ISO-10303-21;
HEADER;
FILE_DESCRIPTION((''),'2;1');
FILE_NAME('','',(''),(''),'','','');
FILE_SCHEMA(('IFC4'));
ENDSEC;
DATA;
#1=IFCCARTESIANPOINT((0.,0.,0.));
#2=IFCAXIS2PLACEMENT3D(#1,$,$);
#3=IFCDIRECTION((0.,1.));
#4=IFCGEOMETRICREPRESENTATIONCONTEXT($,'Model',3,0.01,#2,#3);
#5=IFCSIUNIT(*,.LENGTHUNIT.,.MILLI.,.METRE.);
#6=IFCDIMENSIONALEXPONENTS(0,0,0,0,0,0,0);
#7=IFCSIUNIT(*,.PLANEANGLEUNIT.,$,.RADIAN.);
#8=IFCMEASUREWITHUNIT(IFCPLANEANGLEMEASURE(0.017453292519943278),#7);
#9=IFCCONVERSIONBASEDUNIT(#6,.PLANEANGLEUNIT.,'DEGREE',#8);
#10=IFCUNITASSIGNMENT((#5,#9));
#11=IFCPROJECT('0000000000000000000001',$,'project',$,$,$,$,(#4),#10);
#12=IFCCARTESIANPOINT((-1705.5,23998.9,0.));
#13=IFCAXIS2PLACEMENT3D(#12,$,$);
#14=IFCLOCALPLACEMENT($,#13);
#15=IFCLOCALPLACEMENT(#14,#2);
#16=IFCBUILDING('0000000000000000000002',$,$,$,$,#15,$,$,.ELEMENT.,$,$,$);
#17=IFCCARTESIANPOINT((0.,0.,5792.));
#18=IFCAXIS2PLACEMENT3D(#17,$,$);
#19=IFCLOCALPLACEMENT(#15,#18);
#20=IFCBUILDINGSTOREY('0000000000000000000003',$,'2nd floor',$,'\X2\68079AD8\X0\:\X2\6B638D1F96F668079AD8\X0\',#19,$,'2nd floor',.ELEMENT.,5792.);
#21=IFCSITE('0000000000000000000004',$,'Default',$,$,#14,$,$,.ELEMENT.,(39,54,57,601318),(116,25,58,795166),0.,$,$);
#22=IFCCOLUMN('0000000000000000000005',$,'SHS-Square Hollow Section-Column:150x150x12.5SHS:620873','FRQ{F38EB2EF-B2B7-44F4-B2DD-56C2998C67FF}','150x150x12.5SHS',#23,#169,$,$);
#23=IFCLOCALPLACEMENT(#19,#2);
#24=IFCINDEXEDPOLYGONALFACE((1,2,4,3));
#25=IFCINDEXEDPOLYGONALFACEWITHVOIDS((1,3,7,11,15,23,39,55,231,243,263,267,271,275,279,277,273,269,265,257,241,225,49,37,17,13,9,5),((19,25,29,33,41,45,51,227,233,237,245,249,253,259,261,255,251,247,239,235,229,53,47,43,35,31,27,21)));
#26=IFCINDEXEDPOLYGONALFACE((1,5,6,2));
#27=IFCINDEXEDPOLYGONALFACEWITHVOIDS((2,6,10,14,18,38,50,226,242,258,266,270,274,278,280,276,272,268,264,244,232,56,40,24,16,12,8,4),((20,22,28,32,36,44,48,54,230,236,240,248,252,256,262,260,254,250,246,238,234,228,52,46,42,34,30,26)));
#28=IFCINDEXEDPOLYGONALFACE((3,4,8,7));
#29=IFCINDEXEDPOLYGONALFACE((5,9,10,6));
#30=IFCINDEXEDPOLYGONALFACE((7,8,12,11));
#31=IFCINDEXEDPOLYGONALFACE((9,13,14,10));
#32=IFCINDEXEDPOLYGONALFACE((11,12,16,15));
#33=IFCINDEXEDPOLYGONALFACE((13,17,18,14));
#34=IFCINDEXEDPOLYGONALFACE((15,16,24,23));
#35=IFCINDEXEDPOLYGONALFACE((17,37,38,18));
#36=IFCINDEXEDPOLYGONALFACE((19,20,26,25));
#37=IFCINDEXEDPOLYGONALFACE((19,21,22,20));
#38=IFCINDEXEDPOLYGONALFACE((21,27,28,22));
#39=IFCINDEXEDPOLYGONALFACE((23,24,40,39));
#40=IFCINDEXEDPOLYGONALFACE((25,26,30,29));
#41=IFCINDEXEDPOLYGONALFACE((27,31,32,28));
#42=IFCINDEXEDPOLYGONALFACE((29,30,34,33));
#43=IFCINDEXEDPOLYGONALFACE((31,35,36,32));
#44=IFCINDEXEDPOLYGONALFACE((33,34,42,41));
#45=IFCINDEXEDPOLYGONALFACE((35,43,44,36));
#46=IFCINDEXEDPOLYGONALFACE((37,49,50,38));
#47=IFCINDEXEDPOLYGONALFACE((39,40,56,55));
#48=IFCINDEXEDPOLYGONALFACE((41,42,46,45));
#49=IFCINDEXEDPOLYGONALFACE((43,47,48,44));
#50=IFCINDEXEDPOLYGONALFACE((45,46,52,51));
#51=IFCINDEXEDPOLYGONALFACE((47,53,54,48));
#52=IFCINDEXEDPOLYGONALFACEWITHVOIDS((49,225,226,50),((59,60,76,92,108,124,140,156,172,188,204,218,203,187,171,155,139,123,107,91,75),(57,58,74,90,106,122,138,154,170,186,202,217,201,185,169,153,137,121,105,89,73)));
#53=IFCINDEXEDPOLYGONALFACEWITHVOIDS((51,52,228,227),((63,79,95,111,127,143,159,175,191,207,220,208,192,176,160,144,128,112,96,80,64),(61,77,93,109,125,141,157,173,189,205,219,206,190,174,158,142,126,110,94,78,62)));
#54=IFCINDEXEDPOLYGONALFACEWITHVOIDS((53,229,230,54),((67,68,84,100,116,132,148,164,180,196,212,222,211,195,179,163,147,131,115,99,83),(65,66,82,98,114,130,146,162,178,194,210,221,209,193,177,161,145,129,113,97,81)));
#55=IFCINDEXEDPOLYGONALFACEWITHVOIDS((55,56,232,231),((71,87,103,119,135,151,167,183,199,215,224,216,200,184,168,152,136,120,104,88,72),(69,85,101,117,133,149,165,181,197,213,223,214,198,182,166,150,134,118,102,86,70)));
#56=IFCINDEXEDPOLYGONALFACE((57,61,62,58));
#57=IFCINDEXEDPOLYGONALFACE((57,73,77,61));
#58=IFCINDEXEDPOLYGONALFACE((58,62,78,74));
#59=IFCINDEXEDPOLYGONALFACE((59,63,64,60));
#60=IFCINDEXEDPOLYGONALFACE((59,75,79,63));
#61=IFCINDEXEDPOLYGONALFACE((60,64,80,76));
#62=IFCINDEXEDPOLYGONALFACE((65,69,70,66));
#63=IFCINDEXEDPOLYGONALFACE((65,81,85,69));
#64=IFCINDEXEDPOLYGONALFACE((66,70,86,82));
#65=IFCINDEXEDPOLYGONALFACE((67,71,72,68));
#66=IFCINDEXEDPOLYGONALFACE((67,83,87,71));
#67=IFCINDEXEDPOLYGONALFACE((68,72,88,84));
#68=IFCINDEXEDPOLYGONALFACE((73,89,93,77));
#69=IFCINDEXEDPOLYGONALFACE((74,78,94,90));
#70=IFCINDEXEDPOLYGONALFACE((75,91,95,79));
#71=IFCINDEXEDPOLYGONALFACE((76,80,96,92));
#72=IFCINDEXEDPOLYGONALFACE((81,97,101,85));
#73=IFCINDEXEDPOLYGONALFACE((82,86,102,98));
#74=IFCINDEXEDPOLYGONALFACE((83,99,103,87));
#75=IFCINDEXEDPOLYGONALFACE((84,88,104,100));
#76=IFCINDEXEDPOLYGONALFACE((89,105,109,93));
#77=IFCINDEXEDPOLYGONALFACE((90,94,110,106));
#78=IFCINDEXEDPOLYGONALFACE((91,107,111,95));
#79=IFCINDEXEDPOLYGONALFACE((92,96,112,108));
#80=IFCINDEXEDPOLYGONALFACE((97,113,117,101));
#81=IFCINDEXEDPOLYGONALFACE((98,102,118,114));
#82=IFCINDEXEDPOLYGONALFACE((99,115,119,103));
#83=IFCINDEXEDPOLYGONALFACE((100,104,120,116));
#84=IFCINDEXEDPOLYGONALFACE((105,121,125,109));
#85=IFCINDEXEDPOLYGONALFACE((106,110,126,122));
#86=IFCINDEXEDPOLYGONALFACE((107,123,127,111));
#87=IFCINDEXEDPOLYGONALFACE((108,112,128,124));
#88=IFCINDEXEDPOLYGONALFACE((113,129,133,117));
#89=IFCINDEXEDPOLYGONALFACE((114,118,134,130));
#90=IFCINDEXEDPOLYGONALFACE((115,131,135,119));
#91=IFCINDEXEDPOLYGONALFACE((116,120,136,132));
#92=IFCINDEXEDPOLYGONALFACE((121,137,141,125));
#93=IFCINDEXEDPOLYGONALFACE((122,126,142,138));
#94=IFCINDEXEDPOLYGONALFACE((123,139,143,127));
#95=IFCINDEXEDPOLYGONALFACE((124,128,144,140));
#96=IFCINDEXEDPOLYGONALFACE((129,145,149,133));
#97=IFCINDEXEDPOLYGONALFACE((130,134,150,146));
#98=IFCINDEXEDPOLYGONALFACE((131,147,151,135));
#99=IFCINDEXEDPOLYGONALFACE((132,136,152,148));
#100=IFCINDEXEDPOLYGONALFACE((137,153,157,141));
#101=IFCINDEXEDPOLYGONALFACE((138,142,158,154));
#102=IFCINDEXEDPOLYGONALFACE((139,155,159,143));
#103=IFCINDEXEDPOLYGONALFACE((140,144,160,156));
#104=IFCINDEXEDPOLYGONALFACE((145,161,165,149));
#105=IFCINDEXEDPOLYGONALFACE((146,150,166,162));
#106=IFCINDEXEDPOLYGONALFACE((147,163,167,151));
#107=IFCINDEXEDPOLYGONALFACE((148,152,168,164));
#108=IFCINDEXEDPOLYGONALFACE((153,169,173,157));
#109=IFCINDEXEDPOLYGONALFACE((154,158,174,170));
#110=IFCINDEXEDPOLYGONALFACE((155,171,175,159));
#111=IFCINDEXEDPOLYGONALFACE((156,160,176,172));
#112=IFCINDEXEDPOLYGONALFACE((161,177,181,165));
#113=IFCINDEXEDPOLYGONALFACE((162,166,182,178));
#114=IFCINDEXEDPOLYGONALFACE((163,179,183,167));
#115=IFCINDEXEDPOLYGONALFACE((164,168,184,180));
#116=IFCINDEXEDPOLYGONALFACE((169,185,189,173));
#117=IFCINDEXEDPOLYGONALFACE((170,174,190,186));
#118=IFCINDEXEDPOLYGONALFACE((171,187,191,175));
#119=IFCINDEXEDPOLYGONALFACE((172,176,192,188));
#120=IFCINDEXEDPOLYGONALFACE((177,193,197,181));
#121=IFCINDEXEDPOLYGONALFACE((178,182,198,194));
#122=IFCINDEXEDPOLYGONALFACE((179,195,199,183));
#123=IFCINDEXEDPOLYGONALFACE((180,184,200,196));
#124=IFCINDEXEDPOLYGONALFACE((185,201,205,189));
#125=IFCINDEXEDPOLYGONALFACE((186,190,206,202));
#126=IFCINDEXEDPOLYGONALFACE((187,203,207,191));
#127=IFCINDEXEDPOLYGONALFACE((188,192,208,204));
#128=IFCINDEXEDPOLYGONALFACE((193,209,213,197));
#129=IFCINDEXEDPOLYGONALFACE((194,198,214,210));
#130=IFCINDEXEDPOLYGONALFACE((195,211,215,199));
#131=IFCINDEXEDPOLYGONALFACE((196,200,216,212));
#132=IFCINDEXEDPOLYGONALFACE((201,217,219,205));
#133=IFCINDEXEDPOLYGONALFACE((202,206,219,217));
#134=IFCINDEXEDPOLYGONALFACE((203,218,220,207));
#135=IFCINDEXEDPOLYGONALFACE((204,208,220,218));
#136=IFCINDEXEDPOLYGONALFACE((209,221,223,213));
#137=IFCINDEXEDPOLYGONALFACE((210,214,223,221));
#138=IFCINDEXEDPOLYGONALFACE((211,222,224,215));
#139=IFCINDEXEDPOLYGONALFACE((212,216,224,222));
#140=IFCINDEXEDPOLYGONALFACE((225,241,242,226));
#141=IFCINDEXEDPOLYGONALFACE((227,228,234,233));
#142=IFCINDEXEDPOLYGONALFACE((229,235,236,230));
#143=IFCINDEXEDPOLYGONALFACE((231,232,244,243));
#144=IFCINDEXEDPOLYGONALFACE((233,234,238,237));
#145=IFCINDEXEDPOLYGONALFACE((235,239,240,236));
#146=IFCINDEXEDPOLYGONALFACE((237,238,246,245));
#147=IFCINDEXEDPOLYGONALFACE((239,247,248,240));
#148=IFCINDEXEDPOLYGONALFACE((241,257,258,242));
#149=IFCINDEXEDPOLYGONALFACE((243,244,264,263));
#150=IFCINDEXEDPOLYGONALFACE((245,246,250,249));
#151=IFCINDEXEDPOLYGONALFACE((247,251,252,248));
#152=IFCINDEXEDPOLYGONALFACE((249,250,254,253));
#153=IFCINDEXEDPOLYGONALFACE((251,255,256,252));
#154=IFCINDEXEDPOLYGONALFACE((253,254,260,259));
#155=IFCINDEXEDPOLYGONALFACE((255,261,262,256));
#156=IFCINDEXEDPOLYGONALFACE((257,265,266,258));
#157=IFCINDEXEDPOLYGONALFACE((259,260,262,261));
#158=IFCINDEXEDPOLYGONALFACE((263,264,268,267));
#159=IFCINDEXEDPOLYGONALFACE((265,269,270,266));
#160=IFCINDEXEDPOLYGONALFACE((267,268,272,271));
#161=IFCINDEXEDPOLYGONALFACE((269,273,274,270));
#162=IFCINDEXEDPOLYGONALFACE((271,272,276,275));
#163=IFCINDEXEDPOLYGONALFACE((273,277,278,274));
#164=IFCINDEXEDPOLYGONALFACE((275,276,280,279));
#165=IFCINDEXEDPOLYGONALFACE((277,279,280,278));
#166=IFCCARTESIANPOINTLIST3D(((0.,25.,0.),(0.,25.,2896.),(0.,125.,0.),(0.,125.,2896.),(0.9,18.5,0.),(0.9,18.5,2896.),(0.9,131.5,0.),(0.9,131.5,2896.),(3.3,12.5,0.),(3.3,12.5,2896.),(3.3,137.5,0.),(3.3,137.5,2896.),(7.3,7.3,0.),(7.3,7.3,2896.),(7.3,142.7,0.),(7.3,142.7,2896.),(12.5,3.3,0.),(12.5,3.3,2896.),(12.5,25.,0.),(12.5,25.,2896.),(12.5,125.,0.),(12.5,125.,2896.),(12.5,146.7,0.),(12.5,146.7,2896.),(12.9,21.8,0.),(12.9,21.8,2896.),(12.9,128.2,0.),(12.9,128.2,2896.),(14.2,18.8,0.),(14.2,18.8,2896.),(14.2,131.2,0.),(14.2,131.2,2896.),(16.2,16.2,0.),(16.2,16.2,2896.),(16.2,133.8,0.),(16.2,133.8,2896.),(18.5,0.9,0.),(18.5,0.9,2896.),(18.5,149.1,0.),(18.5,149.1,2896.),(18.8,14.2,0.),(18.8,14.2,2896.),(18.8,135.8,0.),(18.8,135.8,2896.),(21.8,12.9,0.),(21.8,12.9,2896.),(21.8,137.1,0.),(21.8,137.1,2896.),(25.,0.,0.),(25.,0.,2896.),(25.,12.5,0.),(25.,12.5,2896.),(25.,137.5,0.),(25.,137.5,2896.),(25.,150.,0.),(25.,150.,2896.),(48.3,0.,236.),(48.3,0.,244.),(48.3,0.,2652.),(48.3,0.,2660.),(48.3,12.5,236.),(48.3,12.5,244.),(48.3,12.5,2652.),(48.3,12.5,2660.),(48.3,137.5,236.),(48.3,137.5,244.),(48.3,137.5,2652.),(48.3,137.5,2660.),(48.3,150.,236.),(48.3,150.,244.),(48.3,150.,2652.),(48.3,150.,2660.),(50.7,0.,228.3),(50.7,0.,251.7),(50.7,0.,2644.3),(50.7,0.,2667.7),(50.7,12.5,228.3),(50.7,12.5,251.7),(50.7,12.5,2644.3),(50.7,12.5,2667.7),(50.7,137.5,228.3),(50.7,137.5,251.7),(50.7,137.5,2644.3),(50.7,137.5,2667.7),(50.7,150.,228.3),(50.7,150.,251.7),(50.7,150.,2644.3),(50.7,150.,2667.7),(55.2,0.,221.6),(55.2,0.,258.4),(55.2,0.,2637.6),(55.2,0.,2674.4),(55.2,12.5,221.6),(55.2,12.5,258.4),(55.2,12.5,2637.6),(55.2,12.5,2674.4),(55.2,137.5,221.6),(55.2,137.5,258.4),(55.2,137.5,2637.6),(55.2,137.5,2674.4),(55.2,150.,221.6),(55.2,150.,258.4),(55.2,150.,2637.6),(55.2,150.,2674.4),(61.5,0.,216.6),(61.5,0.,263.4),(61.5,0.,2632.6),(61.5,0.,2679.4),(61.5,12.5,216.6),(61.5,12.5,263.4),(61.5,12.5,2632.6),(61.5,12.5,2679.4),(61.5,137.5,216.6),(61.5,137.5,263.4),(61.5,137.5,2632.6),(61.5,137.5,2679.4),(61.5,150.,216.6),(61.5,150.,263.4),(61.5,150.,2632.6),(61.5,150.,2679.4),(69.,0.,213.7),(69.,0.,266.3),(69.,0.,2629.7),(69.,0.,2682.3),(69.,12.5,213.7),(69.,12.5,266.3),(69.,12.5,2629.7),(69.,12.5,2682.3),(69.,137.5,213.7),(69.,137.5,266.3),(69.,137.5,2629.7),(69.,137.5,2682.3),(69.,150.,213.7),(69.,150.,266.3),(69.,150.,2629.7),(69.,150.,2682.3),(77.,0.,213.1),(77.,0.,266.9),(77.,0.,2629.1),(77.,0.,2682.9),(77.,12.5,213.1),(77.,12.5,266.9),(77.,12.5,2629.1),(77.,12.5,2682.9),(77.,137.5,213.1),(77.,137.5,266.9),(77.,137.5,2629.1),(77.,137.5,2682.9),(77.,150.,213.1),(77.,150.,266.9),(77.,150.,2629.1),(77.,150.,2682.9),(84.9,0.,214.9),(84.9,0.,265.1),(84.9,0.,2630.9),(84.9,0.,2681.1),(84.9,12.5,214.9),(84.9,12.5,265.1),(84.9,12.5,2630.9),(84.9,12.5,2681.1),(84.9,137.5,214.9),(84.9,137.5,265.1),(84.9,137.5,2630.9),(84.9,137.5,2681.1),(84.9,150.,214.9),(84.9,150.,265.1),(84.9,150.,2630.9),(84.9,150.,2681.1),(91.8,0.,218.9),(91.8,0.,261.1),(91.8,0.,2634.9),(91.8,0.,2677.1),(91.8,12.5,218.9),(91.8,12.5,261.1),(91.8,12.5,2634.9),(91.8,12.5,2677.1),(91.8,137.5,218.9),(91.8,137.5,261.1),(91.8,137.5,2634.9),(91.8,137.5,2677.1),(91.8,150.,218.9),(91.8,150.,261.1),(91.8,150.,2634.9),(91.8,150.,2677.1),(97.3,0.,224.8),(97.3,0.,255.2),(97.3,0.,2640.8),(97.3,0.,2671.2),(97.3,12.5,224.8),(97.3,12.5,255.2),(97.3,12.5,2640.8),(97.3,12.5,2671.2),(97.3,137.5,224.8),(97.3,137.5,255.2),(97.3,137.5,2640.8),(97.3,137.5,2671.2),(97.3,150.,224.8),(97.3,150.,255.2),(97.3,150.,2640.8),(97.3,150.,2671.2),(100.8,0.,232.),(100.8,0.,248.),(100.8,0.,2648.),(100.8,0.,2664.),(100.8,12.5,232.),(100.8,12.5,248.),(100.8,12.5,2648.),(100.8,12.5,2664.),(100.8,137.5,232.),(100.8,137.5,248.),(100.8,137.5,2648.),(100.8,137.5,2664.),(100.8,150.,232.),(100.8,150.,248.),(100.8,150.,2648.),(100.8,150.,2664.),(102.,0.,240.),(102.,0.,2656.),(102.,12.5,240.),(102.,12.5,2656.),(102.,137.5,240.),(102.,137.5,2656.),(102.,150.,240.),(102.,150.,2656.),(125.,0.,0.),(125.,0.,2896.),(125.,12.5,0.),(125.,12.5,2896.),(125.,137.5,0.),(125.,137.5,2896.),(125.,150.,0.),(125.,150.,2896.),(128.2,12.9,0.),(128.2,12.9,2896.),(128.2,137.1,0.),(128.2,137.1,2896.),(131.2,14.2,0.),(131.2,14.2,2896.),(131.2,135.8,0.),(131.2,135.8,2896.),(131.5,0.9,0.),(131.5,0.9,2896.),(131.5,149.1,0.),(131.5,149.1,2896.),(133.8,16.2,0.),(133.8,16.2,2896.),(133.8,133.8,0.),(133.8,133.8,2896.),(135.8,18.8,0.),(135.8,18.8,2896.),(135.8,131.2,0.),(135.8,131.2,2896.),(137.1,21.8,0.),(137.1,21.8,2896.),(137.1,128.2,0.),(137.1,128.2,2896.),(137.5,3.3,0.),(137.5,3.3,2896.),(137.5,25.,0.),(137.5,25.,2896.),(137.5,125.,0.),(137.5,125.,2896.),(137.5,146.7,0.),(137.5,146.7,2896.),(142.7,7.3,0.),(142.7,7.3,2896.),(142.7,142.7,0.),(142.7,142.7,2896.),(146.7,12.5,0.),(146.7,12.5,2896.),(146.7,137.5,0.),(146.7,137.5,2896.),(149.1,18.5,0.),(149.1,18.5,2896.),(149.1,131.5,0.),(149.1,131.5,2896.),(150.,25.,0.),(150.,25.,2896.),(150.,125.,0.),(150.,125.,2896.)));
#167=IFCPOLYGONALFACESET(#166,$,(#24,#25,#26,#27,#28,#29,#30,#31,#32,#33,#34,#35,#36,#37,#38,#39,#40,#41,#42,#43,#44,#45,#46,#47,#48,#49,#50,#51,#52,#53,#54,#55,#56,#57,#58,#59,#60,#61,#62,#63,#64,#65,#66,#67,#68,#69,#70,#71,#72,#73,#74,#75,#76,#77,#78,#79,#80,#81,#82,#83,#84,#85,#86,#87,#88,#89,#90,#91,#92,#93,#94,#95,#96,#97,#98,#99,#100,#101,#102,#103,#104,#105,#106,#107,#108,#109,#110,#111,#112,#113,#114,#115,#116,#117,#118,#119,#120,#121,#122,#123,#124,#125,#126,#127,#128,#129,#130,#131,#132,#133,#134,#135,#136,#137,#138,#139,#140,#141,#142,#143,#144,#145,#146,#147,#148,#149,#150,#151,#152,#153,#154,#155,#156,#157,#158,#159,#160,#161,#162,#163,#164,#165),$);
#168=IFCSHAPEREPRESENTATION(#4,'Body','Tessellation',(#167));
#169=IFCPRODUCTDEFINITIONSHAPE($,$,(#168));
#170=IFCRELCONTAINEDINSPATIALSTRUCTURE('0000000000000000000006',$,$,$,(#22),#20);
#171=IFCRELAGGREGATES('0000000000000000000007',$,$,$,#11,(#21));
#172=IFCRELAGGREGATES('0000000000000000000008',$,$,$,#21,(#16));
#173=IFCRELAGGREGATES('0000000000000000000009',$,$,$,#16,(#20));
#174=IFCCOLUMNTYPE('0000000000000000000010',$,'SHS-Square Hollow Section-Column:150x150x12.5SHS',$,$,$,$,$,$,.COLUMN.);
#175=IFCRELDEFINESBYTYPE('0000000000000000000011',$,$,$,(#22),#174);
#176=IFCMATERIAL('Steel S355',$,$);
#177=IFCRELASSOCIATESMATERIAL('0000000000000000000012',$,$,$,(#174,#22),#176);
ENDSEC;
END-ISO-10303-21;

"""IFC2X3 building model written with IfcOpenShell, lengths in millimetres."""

from ifc_helpers import new_model, entity, si_unit, converted_unit, direction, frame, frame_2d, origin, origin_2d, place, context, project, spatial, circle_curve, hollow_rectangle, outline, extrude, material, type_object, element, save


model = new_model("IFC2X3")

# Units and contexts
model_context = context("Model", 3, precision=0.01, world=origin(), true_north=direction((0.0, 1.0)))
ifc_project = project(units=[si_unit("LENGTHUNIT", "METRE", prefix="MILLI"), converted_unit("PLANEANGLEUNIT", "DEGREE", entity("IfcPlaneAngleMeasure", 0.017453292519943278), si_unit("PLANEANGLEUNIT", "RADIAN"), dimensions=[0, 0, 0, 0, 0, 0, 0])], contexts=[model_context])

# Site, building, storey
site_placement = place(None, frame((-1705.5, 23998.9, 0.0)))
site = spatial("IfcSite", under=ifc_project, at=site_placement, Name="Default", CompositionType="ELEMENT", RefLatitude=(39, 54, 57, 601318), RefLongitude=(116, 25, 58, 795166), RefElevation=0.0)
building_placement = place(site_placement, origin())
building = spatial("IfcBuilding", under=site, at=building_placement, CompositionType="ELEMENT")
storey_placement = place(building_placement, frame((0.0, 0.0, 5792.0)))
storey = spatial("IfcBuildingStorey", under=building, at=storey_placement, Name="2nd floor", ObjectType="标高:正负零标高", LongName="2nd floor", CompositionType="ELEMENT", Elevation=5792.0)

# Column, openings
ifc_material_1 = material(Name="Steel S355")
column_type_1 = type_object("IfcColumnType", Name="SHS-Square Hollow Section-Column:150x150x12.5SHS", PredefinedType="COLUMN", material=ifc_material_1)
column_1_placement = place(storey_placement, frame((75.0, 75.0, 2896.0), z_axis=(0.0, 0.0, 1.0), x_axis=(0.0, -1.0, 0.0)))
column_1 = element("IfcColumn", 1, at=column_1_placement, inside=storey, type_object=column_type_1, material=ifc_material_1, Name="SHS-Square Hollow Section-Column:150x150x12.5SHS:620873", Description="FRQ{F38EB2EF-B2B7-44F4-B2DD-56C2998C67FF}", ObjectType="150x150x12.5SHS", context=model_context, shape_type="SweptSolid", body=[
    extrude(hollow_rectangle(XDim=150.0, YDim=150.0, WallThickness=12.5, InnerFilletRadius=12.5, OuterFilletRadius=25.0, at=origin_2d()), origin(), (0.0, 0.0, -1.0), 2896.0),
])
opening_1_placement = place(column_1_placement, frame((-175.1, 0.0, -2896.0), z_axis=(1.0, 0.0, 0.0), x_axis=(0.0, 1.0, 0.0)))
element("IfcOpeningElement", 2, at=opening_1_placement, cuts=column_1, ObjectType="Opening", context=model_context, shape_type="SweptSolid", body=[
    extrude(outline(circle_curve(frame_2d((0.0, 240.0), x_axis=(1.0, 0.0)), 27.0)), origin(), (0.0, 0.0, 1.0), 350.2),
])
opening_2_placement = place(column_1_placement, frame((-175.1, 0.0, 0.0), z_axis=(1.0, 0.0, 0.0), x_axis=(0.0, 1.0, 0.0)))
element("IfcOpeningElement", 3, at=opening_2_placement, cuts=column_1, ObjectType="Opening", context=model_context, shape_type="SweptSolid", body=[
    extrude(outline(circle_curve(frame_2d((0.0, -240.0), x_axis=(1.0, 0.0)), 27.0)), origin(), (0.0, 0.0, 1.0), 350.2),
])

save(model, "model.ifc")
